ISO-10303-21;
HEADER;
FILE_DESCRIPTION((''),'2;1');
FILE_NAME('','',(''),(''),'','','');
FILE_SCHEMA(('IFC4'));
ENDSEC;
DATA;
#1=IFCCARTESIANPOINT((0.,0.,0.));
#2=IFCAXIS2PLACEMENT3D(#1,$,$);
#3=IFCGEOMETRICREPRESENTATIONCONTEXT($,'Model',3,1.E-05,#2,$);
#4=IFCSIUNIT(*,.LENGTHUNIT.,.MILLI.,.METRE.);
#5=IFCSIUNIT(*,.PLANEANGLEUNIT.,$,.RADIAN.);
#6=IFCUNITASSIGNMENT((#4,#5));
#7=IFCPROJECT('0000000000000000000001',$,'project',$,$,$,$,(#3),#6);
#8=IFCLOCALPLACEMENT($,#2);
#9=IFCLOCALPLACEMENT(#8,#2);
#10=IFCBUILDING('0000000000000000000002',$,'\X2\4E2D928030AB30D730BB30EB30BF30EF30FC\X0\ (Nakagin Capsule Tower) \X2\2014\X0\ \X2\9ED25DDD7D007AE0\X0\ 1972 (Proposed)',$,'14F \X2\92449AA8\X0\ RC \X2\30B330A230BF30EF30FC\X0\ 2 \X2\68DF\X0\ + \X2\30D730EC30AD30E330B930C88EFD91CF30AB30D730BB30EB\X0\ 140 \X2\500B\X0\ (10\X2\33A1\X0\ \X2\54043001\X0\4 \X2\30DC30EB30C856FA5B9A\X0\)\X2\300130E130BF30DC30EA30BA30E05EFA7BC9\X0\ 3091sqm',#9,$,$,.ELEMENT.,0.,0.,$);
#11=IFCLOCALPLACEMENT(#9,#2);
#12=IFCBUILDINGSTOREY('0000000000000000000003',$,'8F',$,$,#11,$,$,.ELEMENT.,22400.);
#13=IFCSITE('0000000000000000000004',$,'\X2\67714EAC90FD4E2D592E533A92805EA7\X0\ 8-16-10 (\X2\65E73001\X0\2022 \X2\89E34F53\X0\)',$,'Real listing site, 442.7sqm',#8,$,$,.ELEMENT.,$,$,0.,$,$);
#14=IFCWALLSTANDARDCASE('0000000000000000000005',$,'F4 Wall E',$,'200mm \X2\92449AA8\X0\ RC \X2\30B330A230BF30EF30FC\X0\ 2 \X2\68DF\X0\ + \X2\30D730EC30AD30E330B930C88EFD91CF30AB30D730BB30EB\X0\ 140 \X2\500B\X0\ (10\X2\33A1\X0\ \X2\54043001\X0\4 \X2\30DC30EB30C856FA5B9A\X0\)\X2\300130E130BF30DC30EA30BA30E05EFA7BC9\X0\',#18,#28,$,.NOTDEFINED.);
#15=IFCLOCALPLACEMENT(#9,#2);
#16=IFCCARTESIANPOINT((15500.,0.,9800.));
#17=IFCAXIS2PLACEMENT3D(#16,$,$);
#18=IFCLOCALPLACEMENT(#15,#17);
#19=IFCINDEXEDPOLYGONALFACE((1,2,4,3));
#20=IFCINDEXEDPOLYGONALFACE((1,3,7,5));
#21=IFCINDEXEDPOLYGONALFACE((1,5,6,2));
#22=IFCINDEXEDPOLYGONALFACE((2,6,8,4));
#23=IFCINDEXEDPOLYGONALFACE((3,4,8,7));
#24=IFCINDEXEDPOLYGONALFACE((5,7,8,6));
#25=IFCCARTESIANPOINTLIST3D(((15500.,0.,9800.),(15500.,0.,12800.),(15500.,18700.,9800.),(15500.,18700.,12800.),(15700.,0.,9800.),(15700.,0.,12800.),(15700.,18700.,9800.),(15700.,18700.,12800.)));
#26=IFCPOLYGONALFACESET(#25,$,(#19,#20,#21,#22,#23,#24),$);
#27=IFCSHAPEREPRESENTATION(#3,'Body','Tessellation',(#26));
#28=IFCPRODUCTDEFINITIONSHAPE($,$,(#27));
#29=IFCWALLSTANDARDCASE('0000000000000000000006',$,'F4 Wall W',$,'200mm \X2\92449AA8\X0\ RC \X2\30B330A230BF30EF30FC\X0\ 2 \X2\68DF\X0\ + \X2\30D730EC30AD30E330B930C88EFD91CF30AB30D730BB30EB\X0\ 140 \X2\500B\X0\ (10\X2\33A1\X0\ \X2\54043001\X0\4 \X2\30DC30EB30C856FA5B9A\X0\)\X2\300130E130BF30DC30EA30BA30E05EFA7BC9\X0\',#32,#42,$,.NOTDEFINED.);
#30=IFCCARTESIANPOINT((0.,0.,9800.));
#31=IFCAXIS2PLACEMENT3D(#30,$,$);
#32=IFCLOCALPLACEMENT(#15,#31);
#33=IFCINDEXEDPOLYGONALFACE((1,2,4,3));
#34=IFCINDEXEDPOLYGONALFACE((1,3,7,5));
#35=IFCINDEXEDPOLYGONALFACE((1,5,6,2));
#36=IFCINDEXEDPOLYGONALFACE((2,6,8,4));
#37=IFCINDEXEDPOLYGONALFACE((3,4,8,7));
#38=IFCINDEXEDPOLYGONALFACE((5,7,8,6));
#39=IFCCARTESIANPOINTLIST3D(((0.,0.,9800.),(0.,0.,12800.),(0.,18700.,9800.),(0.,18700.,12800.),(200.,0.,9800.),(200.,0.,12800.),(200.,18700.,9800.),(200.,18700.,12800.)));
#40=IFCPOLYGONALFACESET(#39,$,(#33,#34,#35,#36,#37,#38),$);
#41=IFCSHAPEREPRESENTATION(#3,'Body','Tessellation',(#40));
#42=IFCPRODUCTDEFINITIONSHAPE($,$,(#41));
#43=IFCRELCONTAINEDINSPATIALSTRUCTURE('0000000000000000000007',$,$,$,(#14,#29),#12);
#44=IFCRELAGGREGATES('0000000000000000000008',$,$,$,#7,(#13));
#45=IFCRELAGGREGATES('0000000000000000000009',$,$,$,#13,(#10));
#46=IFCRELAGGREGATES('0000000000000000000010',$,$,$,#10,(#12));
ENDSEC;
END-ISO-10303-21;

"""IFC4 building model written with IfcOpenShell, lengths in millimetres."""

from ifc_helpers import new_model, si_unit, frame, frame_2d, origin, place, context, project, spatial, rectangle, extrude, element, save


model = new_model("IFC4")

# Units and contexts
model_context = context("Model", 3, precision=1e-05, world=origin())
ifc_project = project(units=[si_unit("LENGTHUNIT", "METRE", prefix="MILLI"), si_unit("PLANEANGLEUNIT", "RADIAN")], contexts=[model_context])

# Site, building, storey
site_placement = place(None, origin())
site = spatial("IfcSite", under=ifc_project, at=site_placement, Name="東京都中央区銀座 8-16-10 (旧、2022 解体)", ObjectType="Real listing site, 442.7sqm", CompositionType="ELEMENT", RefElevation=0.0)
building_placement = place(site_placement, origin())
building = spatial("IfcBuilding", under=site, at=building_placement, Name="中銀カプセルタワー (Nakagin Capsule Tower) — 黒川紀章 1972 (Proposed)", ObjectType="14F 鉄骨 RC コアタワー 2 棟 + プレキャスト軽量カプセル 140 個 (10㎡ 各、4 ボルト固定)、メタボリズム建築 3091sqm", CompositionType="ELEMENT", ElevationOfRefHeight=0.0, ElevationOfTerrain=0.0)
storey_placement = place(building_placement, origin())
storey = spatial("IfcBuildingStorey", under=building, at=storey_placement, Name="8F", CompositionType="ELEMENT", Elevation=22400.0)

# Walls
placement = place(building_placement, origin())
wall_1_placement = place(placement, frame((15500.0, 0.0, 9800.0)))
element("IfcWallStandardCase", 1, at=wall_1_placement, inside=storey, Name="F4 Wall E", ObjectType="200mm 鉄骨 RC コアタワー 2 棟 + プレキャスト軽量カプセル 140 個 (10㎡ 各、4 ボルト固定)、メタボリズム建築", PredefinedType="NOTDEFINED", context=model_context, shape_type="SweptSolid", body=[
    extrude(rectangle(XDim=200.0, YDim=18700.0, at=frame_2d((100.0, 9350.0))), frame((15500.0, 0.0, 9800.0)), (0.0, 0.0, 1.0), 3000.0),
])
wall_2_placement = place(placement, frame((0.0, 0.0, 9800.0)))
element("IfcWallStandardCase", 2, at=wall_2_placement, inside=storey, Name="F4 Wall W", ObjectType="200mm 鉄骨 RC コアタワー 2 棟 + プレキャスト軽量カプセル 140 個 (10㎡ 各、4 ボルト固定)、メタボリズム建築", PredefinedType="NOTDEFINED", context=model_context, shape_type="SweptSolid", body=[
    extrude(rectangle(XDim=200.0, YDim=18700.0, at=frame_2d((100.0, 9350.0))), frame((0.0, 0.0, 9800.0)), (0.0, 0.0, 1.0), 3000.0),
])

save(model, "model.ifc")
